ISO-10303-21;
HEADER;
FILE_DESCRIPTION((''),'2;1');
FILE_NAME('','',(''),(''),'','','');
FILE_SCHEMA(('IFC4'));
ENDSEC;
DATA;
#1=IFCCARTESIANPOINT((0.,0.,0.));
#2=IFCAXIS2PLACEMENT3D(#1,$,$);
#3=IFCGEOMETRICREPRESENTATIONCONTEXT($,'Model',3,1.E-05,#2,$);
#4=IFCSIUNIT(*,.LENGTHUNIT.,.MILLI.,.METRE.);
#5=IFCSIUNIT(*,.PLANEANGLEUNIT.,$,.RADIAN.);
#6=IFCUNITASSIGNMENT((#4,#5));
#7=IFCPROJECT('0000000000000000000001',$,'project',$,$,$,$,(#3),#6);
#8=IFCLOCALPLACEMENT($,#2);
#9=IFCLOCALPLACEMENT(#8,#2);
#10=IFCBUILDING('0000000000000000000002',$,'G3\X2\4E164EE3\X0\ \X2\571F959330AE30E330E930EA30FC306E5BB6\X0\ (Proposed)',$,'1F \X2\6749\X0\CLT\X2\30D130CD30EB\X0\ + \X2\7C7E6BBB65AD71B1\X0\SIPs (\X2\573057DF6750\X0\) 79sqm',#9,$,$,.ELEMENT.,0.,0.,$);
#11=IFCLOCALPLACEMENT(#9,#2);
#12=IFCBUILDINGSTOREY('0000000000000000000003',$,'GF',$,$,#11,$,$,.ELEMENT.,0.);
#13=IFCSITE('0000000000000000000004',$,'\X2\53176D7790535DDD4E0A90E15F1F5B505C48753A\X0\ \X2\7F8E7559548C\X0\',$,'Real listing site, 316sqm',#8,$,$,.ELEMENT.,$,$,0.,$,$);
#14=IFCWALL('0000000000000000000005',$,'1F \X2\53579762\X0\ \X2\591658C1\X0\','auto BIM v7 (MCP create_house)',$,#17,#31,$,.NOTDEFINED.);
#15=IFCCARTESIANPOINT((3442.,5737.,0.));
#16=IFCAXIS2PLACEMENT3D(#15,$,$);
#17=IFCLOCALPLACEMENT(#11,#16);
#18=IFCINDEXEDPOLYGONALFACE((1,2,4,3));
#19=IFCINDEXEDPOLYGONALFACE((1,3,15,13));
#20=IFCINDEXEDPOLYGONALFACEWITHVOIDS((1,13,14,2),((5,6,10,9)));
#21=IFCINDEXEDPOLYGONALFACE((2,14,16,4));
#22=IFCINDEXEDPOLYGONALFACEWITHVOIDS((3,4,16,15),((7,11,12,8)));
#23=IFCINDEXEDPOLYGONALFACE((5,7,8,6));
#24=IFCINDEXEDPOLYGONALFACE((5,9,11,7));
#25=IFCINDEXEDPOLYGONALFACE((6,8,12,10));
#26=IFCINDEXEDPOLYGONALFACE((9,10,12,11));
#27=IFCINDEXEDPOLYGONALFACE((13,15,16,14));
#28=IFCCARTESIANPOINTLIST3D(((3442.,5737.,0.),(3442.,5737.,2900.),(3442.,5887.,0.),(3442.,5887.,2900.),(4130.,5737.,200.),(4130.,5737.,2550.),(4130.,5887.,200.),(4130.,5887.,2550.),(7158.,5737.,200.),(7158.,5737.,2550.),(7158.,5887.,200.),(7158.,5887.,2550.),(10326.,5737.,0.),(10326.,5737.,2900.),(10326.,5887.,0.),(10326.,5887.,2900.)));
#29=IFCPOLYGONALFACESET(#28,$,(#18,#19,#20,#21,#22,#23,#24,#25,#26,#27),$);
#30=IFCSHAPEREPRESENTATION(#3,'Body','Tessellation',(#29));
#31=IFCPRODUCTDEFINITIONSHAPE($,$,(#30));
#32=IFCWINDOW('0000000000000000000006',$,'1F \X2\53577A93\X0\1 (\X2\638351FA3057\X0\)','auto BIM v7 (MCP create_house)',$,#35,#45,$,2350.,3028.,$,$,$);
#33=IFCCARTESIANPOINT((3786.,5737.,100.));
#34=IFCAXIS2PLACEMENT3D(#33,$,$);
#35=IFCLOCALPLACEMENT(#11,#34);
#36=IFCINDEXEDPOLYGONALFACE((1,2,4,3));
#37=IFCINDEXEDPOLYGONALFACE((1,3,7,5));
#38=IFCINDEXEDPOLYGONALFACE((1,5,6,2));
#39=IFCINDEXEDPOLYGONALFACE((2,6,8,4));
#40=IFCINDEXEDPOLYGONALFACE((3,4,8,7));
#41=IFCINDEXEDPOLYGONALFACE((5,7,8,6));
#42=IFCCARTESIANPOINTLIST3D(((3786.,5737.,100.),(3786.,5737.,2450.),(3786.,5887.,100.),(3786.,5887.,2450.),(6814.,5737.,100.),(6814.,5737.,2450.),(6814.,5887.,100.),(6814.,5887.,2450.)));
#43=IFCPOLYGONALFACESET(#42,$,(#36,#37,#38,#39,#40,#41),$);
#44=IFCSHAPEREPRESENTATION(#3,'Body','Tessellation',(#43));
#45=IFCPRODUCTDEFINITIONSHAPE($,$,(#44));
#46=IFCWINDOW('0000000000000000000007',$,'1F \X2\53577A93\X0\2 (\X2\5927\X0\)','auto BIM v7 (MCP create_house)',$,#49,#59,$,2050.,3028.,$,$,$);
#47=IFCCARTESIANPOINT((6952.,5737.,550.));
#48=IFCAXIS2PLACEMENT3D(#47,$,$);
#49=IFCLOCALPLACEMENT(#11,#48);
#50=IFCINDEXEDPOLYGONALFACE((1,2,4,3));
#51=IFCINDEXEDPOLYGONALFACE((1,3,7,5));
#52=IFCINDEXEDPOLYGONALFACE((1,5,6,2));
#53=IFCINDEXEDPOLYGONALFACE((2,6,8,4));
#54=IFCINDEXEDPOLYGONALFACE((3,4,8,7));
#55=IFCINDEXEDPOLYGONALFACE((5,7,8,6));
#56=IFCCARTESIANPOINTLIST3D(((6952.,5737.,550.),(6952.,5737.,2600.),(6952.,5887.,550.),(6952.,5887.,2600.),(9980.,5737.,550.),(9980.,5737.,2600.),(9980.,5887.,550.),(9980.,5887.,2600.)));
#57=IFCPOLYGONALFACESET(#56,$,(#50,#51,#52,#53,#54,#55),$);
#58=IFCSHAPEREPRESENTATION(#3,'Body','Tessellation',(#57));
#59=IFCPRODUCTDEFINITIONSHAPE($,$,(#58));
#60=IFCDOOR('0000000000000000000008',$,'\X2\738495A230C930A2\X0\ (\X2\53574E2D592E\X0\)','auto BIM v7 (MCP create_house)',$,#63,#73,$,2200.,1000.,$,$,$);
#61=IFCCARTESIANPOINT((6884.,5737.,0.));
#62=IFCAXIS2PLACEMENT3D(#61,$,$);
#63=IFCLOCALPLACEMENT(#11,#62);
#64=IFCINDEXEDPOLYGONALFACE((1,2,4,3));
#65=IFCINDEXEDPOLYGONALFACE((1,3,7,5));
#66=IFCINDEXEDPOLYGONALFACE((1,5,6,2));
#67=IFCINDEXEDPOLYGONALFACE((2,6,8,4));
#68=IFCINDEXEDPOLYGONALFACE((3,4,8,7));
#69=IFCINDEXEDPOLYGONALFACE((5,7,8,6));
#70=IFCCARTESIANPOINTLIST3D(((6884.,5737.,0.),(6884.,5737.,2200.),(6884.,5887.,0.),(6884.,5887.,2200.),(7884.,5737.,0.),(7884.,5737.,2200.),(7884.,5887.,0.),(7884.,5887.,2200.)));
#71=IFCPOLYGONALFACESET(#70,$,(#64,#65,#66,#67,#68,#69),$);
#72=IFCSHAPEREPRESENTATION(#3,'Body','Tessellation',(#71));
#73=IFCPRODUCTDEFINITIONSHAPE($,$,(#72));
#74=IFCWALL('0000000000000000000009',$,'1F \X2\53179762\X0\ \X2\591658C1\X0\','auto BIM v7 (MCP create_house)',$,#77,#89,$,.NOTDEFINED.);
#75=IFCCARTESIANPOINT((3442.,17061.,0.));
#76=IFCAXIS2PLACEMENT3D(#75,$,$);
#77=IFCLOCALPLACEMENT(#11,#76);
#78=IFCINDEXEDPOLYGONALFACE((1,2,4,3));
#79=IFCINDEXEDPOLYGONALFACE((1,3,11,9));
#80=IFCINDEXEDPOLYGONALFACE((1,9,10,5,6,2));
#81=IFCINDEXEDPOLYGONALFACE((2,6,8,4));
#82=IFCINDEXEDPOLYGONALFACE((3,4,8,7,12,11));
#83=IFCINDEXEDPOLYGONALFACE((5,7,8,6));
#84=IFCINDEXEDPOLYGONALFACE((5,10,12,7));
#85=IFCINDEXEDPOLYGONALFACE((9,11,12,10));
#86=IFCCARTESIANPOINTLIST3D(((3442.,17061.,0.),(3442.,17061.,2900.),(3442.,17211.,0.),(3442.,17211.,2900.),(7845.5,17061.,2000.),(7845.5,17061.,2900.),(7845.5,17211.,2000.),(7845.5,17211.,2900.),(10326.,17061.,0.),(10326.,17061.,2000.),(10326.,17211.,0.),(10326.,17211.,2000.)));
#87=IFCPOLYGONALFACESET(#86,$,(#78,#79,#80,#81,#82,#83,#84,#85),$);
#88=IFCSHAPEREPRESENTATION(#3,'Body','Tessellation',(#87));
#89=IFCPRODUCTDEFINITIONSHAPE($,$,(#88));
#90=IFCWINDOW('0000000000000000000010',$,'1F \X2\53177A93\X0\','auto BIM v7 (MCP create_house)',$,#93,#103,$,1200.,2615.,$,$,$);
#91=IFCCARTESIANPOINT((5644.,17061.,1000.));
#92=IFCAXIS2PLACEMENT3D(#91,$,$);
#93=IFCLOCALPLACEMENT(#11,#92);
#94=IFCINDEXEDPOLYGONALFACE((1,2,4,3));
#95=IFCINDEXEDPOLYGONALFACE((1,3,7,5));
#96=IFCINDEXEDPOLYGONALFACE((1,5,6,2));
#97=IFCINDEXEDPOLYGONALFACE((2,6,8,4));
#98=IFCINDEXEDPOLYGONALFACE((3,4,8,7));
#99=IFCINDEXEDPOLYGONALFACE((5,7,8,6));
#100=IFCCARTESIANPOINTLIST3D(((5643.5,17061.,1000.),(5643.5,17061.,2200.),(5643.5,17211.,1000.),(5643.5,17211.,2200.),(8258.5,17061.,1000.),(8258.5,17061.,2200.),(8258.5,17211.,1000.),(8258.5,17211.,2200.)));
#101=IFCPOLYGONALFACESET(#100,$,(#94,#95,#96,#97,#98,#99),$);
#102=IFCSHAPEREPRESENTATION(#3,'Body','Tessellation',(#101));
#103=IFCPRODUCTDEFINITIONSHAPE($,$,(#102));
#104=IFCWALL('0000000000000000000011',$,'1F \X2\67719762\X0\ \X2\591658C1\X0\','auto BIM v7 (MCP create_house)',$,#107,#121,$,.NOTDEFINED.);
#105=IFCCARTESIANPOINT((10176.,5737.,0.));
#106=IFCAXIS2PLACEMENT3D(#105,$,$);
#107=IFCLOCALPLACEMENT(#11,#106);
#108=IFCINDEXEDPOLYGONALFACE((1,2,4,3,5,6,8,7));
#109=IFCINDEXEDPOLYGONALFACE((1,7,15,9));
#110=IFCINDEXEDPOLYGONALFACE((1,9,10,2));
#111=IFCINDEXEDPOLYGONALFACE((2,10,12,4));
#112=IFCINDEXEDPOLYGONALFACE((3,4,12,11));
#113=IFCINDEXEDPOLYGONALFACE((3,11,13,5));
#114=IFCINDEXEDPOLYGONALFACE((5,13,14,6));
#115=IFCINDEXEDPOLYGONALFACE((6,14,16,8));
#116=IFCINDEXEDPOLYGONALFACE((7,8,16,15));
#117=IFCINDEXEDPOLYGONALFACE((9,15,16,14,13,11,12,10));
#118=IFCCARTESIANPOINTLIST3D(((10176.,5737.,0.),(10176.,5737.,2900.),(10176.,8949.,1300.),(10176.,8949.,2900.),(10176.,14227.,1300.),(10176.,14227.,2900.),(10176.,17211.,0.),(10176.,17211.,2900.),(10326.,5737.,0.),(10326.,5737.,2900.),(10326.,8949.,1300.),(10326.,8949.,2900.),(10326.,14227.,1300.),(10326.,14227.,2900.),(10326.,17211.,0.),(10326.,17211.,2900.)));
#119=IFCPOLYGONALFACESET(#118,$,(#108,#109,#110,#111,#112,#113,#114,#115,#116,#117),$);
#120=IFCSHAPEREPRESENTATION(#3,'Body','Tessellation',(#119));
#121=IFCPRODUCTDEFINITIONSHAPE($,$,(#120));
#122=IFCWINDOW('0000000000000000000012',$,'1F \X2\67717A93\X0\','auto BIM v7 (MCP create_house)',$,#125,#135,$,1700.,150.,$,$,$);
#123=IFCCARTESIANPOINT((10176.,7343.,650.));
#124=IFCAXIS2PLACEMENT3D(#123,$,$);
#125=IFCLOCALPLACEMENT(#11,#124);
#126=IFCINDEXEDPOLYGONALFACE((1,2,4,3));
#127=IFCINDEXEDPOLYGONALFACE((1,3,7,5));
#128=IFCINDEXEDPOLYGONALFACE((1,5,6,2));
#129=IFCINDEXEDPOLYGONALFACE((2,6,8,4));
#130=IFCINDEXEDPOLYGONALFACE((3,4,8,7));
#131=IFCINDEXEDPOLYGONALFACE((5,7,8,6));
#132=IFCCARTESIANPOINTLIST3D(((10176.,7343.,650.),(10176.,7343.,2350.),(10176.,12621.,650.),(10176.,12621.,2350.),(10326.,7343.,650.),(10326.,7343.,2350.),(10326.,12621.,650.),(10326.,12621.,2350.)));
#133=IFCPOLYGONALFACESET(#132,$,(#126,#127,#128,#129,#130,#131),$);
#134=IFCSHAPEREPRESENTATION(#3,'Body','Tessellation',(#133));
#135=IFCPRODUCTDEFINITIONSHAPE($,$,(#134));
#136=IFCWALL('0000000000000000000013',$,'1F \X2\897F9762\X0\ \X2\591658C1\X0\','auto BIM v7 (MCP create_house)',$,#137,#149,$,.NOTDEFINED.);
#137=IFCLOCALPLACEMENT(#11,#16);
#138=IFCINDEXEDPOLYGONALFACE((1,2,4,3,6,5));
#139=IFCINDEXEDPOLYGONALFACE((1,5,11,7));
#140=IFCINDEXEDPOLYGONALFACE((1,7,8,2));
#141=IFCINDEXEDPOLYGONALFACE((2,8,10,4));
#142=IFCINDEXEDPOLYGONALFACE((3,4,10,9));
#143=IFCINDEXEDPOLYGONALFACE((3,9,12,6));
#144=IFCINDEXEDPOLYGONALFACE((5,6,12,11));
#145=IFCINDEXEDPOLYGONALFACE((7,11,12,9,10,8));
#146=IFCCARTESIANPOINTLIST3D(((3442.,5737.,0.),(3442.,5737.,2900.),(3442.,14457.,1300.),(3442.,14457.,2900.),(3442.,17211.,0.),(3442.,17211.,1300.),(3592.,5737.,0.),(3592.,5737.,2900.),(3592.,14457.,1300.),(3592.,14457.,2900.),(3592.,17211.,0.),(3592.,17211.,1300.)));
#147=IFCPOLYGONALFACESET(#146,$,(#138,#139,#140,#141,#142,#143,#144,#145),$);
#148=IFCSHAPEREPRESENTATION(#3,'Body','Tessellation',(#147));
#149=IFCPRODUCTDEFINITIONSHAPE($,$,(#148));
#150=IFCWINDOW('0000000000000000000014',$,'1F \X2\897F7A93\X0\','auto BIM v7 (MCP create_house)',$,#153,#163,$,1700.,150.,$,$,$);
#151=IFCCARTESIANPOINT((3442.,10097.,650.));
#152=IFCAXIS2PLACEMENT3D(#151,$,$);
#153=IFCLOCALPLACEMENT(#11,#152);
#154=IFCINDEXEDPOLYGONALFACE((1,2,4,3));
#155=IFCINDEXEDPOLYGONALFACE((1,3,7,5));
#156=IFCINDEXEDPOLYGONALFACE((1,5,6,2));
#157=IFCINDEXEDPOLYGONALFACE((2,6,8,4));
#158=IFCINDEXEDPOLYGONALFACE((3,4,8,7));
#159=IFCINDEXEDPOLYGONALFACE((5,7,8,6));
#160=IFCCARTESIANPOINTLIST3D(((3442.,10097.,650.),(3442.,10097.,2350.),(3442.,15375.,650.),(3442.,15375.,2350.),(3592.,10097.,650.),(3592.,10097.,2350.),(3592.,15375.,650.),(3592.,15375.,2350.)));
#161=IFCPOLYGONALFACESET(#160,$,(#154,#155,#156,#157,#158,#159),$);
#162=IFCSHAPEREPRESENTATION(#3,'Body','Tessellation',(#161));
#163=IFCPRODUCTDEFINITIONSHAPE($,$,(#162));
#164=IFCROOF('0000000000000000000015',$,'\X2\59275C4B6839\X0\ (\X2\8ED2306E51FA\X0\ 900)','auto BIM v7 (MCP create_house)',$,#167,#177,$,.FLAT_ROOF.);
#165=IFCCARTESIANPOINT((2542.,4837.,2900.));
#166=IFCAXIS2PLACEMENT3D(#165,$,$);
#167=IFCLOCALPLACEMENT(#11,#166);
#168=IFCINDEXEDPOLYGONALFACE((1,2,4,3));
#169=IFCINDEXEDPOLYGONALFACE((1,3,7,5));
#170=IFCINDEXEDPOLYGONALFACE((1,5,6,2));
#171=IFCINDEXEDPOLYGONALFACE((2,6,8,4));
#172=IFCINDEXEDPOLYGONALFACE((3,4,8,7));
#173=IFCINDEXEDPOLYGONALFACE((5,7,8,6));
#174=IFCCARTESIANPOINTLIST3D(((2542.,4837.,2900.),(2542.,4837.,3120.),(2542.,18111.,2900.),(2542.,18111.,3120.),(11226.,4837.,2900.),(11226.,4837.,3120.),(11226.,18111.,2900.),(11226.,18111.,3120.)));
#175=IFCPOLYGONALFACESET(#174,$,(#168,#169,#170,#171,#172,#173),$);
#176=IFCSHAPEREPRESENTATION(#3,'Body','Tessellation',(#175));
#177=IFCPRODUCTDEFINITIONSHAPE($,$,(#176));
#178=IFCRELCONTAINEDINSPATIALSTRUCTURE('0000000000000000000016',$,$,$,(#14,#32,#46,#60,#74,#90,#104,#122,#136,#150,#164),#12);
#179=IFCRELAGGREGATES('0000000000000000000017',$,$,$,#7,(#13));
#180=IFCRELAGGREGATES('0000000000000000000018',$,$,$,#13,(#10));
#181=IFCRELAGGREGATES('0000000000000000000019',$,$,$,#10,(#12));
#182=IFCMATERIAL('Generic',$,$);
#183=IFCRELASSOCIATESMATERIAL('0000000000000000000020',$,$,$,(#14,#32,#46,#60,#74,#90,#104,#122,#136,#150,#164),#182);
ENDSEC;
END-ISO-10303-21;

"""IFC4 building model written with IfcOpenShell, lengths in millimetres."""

from ifc_helpers import new_model, si_unit, frame, frame_2d, origin, place, context, project, spatial, rectangle, extrude, material, element, fill, save


model = new_model("IFC4")

# Units and contexts
model_context = context("Model", 3, precision=1e-05, world=origin())
ifc_project = project(units=[si_unit("LENGTHUNIT", "METRE", prefix="MILLI"), si_unit("PLANEANGLEUNIT", "RADIAN")], contexts=[model_context])

# Site, building, storey
site_placement = place(None, origin())
site = spatial("IfcSite", under=ifc_project, at=site_placement, Name="北海道川上郡弟子屈町 美留和", ObjectType="Real listing site, 316sqm", CompositionType="ELEMENT", RefElevation=0.0)
building_placement = place(site_placement, origin())
building = spatial("IfcBuilding", under=site, at=building_placement, Name="G3世代 土間ギャラリーの家 (Proposed)", ObjectType="1F 杉CLTパネル + 籾殻断熱SIPs (地域材) 79sqm", CompositionType="ELEMENT", ElevationOfRefHeight=0.0, ElevationOfTerrain=0.0)
storey_placement = place(building_placement, origin())
storey = spatial("IfcBuildingStorey", under=building, at=storey_placement, Name="GF", CompositionType="ELEMENT", Elevation=0.0)

# Shared definitions
ifc_material = material(Name="Generic")

# Wall, openings, windows, door
wall_1_placement = place(storey_placement, frame((3442.0, 5737.0, 0.0)))
wall_1 = element("IfcWall", 1, at=wall_1_placement, inside=storey, material=ifc_material, Name="1F 南面 外壁", Description="auto BIM v7 (MCP create_house)", PredefinedType="NOTDEFINED", context=model_context, shape_type="SweptSolid", body=[
    extrude(rectangle(XDim=6884.0, YDim=150.0, at=frame_2d((3442.0, 75.0))), frame((3442.0, 5737.0, 0.0)), (0.0, 0.0, 1.0), 2900.0),
])
opening_1_placement = place(storey_placement, frame((3786.0, 5737.0, 100.0)))
opening_1 = element("IfcOpeningElement", 2, at=opening_1_placement, cuts=wall_1, PredefinedType="NOTDEFINED", context=model_context, shape_type="SweptSolid", body=[
    extrude(rectangle(XDim=3028.0, YDim=150.0, at=frame_2d((1514.0, 75.0))), frame((3786.0, 5737.0, 100.0)), (0.0, 0.0, 1.0), 2350.0),
])
opening_2_placement = place(storey_placement, frame((6952.0, 5737.0, 550.0)))
opening_2 = element("IfcOpeningElement", 3, at=opening_2_placement, cuts=wall_1, PredefinedType="NOTDEFINED", context=model_context, shape_type="SweptSolid", body=[
    extrude(rectangle(XDim=3028.0, YDim=150.0, at=frame_2d((1514.0, 75.0))), frame((6952.0, 5737.0, 550.0)), (0.0, 0.0, 1.0), 2050.0),
])
opening_3_placement = place(storey_placement, frame((6884.0, 5737.0, 0.0)))
opening_3 = element("IfcOpeningElement", 4, at=opening_3_placement, cuts=wall_1, PredefinedType="NOTDEFINED", context=model_context, shape_type="SweptSolid", body=[
    extrude(rectangle(XDim=1000.0, YDim=150.0, at=frame_2d((500.0, 75.0))), frame((6884.0, 5737.0, 0.0)), (0.0, 0.0, 1.0), 2200.0),
])
window_1_placement = place(storey_placement, frame((3786.0, 5737.0, 100.0)))
window_1 = element("IfcWindow", 5, at=window_1_placement, inside=storey, material=ifc_material, Name="1F 南窓1 (掃出し)", Description="auto BIM v7 (MCP create_house)", OverallHeight=2350.0, OverallWidth=3028.0, context=model_context, shape_type="SweptSolid", body=[
    extrude(rectangle(XDim=3028.0, YDim=150.0, at=frame_2d((1514.0, 75.0))), frame((3786.0, 5737.0, 100.0)), (0.0, 0.0, 1.0), 2350.0),
])
fill(opening_1, window_1)
window_2_placement = place(storey_placement, frame((6952.0, 5737.0, 550.0)))
window_2 = element("IfcWindow", 6, at=window_2_placement, inside=storey, material=ifc_material, Name="1F 南窓2 (大)", Description="auto BIM v7 (MCP create_house)", OverallHeight=2050.0, OverallWidth=3028.0, context=model_context, shape_type="SweptSolid", body=[
    extrude(rectangle(XDim=3028.0, YDim=150.0, at=frame_2d((1514.0, 75.0))), frame((6952.0, 5737.0, 550.0)), (0.0, 0.0, 1.0), 2050.0),
])
fill(opening_2, window_2)
door_placement = place(storey_placement, frame((6884.0, 5737.0, 0.0)))
door = element("IfcDoor", 7, at=door_placement, inside=storey, material=ifc_material, Name="玄関ドア (南中央)", Description="auto BIM v7 (MCP create_house)", OverallHeight=2200.0, OverallWidth=1000.0, context=model_context, shape_type="SweptSolid", body=[
    extrude(rectangle(XDim=1000.0, YDim=150.0, at=frame_2d((500.0, 75.0))), frame((6884.0, 5737.0, 0.0)), (0.0, 0.0, 1.0), 2200.0),
])
fill(opening_3, door)

# Walls, openings, windows
wall_2_placement = place(storey_placement, frame((3442.0, 17061.0, 0.0)))
wall_2 = element("IfcWall", 8, at=wall_2_placement, inside=storey, material=ifc_material, Name="1F 北面 外壁", Description="auto BIM v7 (MCP create_house)", PredefinedType="NOTDEFINED", context=model_context, shape_type="SweptSolid", body=[
    extrude(rectangle(XDim=6884.0, YDim=150.0, at=frame_2d((3442.0, 75.0))), frame((3442.0, 17061.0, 0.0)), (0.0, 0.0, 1.0), 2900.0),
])
opening_4_placement = place(storey_placement, frame((5644.0, 17061.0, 1000.0)))
opening_4 = element("IfcOpeningElement", 9, at=opening_4_placement, cuts=wall_2, PredefinedType="NOTDEFINED", context=model_context, shape_type="SweptSolid", body=[
    extrude(rectangle(XDim=2615.0, YDim=150.0, at=frame_2d((1307.0, 75.0))), frame((5644.0, 17061.0, 1000.0)), (0.0, 0.0, 1.0), 1200.0),
])
window_3_placement = place(storey_placement, frame((5644.0, 17061.0, 1000.0)))
window_3 = element("IfcWindow", 10, at=window_3_placement, inside=storey, material=ifc_material, Name="1F 北窓", Description="auto BIM v7 (MCP create_house)", OverallHeight=1200.0, OverallWidth=2615.0, context=model_context, shape_type="SweptSolid", body=[
    extrude(rectangle(XDim=2615.0, YDim=150.0, at=frame_2d((1307.0, 75.0))), frame((5644.0, 17061.0, 1000.0)), (0.0, 0.0, 1.0), 1200.0),
])
fill(opening_4, window_3)
wall_3_placement = place(storey_placement, frame((10176.0, 5737.0, 0.0)))
wall_3 = element("IfcWall", 11, at=wall_3_placement, inside=storey, material=ifc_material, Name="1F 東面 外壁", Description="auto BIM v7 (MCP create_house)", PredefinedType="NOTDEFINED", context=model_context, shape_type="SweptSolid", body=[
    extrude(rectangle(XDim=150.0, YDim=11474.0, at=frame_2d((75.0, 5737.0))), frame((10176.0, 5737.0, 0.0)), (0.0, 0.0, 1.0), 2900.0),
])
opening_5_placement = place(storey_placement, frame((10176.0, 7343.0, 650.0)))
opening_5 = element("IfcOpeningElement", 12, at=opening_5_placement, cuts=wall_3, PredefinedType="NOTDEFINED", context=model_context, shape_type="SweptSolid", body=[
    extrude(rectangle(XDim=150.0, YDim=5278.0, at=frame_2d((75.0, 2639.0))), frame((10176.0, 7343.0, 650.0)), (0.0, 0.0, 1.0), 1700.0),
])
window_4_placement = place(storey_placement, frame((10176.0, 7343.0, 650.0)))
window_4 = element("IfcWindow", 13, at=window_4_placement, inside=storey, material=ifc_material, Name="1F 東窓", Description="auto BIM v7 (MCP create_house)", OverallHeight=1700.0, OverallWidth=150.0, context=model_context, shape_type="SweptSolid", body=[
    extrude(rectangle(XDim=150.0, YDim=5278.0, at=frame_2d((75.0, 2639.0))), frame((10176.0, 7343.0, 650.0)), (0.0, 0.0, 1.0), 1700.0),
])
fill(opening_5, window_4)
wall_4_placement = place(storey_placement, frame((3442.0, 5737.0, 0.0)))
wall_4 = element("IfcWall", 14, at=wall_4_placement, inside=storey, material=ifc_material, Name="1F 西面 外壁", Description="auto BIM v7 (MCP create_house)", PredefinedType="NOTDEFINED", context=model_context, shape_type="SweptSolid", body=[
    extrude(rectangle(XDim=150.0, YDim=11474.0, at=frame_2d((75.0, 5737.0))), frame((3442.0, 5737.0, 0.0)), (0.0, 0.0, 1.0), 2900.0),
])
opening_6_placement = place(storey_placement, frame((3442.0, 10097.0, 650.0)))
opening_6 = element("IfcOpeningElement", 15, at=opening_6_placement, cuts=wall_4, PredefinedType="NOTDEFINED", context=model_context, shape_type="SweptSolid", body=[
    extrude(rectangle(XDim=150.0, YDim=5278.0, at=frame_2d((75.0, 2639.0))), frame((3442.0, 10097.0, 650.0)), (0.0, 0.0, 1.0), 1700.0),
])
window_5_placement = place(storey_placement, frame((3442.0, 10097.0, 650.0)))
window_5 = element("IfcWindow", 16, at=window_5_placement, inside=storey, material=ifc_material, Name="1F 西窓", Description="auto BIM v7 (MCP create_house)", OverallHeight=1700.0, OverallWidth=150.0, context=model_context, shape_type="SweptSolid", body=[
    extrude(rectangle(XDim=150.0, YDim=5278.0, at=frame_2d((75.0, 2639.0))), frame((3442.0, 10097.0, 650.0)), (0.0, 0.0, 1.0), 1700.0),
])
fill(opening_6, window_5)

# Roof
roof_placement = place(storey_placement, frame((2542.0, 4837.0, 2900.0)))
element("IfcRoof", 17, at=roof_placement, inside=storey, material=ifc_material, Name="大屋根 (軒の出 900)", Description="auto BIM v7 (MCP create_house)", PredefinedType="FLAT_ROOF", context=model_context, shape_type="SweptSolid", body=[
    extrude(rectangle(XDim=8684.0, YDim=13274.0, at=frame_2d((4342.0, 6637.0))), frame((2542.0, 4837.0, 2900.0)), (0.0, 0.0, 1.0), 220.0),
])

save(model, "model.ifc")
